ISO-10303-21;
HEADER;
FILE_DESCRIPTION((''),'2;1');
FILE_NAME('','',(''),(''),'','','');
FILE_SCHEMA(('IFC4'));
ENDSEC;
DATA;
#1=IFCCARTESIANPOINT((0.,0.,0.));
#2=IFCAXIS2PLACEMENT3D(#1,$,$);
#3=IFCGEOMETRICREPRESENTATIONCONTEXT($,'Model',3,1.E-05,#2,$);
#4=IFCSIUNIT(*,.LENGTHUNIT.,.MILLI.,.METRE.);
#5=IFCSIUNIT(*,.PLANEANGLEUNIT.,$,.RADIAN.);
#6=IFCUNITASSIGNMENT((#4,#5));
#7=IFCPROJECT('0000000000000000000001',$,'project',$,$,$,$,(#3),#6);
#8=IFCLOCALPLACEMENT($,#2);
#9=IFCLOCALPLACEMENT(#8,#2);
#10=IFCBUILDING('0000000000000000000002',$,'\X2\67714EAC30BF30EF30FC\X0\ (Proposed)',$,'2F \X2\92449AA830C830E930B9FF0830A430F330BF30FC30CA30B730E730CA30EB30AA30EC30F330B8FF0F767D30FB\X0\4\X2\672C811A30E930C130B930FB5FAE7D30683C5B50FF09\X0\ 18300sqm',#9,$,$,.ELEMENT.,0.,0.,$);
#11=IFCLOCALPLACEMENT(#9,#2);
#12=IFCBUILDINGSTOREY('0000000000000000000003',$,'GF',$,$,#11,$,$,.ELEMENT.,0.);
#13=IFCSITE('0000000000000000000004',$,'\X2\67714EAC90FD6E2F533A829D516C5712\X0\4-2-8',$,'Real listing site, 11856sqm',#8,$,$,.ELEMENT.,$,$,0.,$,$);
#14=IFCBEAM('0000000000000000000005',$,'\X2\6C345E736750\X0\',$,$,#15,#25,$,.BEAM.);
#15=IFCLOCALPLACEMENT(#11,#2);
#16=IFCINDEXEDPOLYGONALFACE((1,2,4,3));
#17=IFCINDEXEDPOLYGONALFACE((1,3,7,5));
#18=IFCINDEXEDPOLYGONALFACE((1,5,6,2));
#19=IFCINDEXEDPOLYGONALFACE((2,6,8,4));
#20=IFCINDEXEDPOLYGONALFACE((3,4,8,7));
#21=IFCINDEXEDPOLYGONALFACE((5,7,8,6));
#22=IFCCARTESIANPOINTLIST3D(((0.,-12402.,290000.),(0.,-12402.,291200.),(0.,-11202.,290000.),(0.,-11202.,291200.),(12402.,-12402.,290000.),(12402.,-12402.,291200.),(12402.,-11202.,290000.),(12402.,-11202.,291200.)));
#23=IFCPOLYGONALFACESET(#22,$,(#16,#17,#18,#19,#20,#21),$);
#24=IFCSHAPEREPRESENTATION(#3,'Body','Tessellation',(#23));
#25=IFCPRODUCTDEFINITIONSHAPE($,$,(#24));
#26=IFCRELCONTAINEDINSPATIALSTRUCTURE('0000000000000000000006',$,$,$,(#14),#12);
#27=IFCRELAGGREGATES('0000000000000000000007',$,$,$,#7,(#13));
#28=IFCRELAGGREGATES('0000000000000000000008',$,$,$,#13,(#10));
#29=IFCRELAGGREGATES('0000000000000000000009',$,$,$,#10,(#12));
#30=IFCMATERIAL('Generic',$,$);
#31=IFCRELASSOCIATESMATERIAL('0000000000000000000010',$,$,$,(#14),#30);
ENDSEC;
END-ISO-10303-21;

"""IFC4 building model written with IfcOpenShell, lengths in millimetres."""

from ifc_helpers import new_model, si_unit, frame, frame_2d, origin, place, context, project, spatial, rectangle, extrude, material, element, save


model = new_model("IFC4")

# Units and contexts
model_context = context("Model", 3, precision=1e-05, world=origin())
ifc_project = project(units=[si_unit("LENGTHUNIT", "METRE", prefix="MILLI"), si_unit("PLANEANGLEUNIT", "RADIAN")], contexts=[model_context])

# Site, building, storey
site_placement = place(None, origin())
site = spatial("IfcSite", under=ifc_project, at=site_placement, Name="東京都港区芝公園4-2-8", ObjectType="Real listing site, 11856sqm", CompositionType="ELEMENT", RefElevation=0.0)
building_placement = place(site_placement, origin())
building = spatial("IfcBuilding", under=site, at=building_placement, Name="東京タワー (Proposed)", ObjectType="2F 鉄骨トラス（インターナショナルオレンジ／白・4本脚ラチス・微細格子） 18300sqm", CompositionType="ELEMENT", ElevationOfRefHeight=0.0, ElevationOfTerrain=0.0)
storey_placement = place(building_placement, origin())
storey = spatial("IfcBuildingStorey", under=building, at=storey_placement, Name="GF", CompositionType="ELEMENT", Elevation=0.0)

# Beam
ifc_material = material(Name="Generic")
beam_placement = place(storey_placement, frame((0.0, -6201.0, 145000.0)))
element("IfcBeam", 1, at=beam_placement, inside=storey, material=ifc_material, Name="水平材", PredefinedType="BEAM", context=model_context, shape_type="SweptSolid", body=[
    extrude(rectangle(XDim=12402.0, YDim=1200.0, at=frame_2d((6201.0, 600.0))), frame((0.0, -6201.0, 145000.0)), (0.0, 0.0, 1.0), 1200.0),
])

save(model, "model.ifc")
